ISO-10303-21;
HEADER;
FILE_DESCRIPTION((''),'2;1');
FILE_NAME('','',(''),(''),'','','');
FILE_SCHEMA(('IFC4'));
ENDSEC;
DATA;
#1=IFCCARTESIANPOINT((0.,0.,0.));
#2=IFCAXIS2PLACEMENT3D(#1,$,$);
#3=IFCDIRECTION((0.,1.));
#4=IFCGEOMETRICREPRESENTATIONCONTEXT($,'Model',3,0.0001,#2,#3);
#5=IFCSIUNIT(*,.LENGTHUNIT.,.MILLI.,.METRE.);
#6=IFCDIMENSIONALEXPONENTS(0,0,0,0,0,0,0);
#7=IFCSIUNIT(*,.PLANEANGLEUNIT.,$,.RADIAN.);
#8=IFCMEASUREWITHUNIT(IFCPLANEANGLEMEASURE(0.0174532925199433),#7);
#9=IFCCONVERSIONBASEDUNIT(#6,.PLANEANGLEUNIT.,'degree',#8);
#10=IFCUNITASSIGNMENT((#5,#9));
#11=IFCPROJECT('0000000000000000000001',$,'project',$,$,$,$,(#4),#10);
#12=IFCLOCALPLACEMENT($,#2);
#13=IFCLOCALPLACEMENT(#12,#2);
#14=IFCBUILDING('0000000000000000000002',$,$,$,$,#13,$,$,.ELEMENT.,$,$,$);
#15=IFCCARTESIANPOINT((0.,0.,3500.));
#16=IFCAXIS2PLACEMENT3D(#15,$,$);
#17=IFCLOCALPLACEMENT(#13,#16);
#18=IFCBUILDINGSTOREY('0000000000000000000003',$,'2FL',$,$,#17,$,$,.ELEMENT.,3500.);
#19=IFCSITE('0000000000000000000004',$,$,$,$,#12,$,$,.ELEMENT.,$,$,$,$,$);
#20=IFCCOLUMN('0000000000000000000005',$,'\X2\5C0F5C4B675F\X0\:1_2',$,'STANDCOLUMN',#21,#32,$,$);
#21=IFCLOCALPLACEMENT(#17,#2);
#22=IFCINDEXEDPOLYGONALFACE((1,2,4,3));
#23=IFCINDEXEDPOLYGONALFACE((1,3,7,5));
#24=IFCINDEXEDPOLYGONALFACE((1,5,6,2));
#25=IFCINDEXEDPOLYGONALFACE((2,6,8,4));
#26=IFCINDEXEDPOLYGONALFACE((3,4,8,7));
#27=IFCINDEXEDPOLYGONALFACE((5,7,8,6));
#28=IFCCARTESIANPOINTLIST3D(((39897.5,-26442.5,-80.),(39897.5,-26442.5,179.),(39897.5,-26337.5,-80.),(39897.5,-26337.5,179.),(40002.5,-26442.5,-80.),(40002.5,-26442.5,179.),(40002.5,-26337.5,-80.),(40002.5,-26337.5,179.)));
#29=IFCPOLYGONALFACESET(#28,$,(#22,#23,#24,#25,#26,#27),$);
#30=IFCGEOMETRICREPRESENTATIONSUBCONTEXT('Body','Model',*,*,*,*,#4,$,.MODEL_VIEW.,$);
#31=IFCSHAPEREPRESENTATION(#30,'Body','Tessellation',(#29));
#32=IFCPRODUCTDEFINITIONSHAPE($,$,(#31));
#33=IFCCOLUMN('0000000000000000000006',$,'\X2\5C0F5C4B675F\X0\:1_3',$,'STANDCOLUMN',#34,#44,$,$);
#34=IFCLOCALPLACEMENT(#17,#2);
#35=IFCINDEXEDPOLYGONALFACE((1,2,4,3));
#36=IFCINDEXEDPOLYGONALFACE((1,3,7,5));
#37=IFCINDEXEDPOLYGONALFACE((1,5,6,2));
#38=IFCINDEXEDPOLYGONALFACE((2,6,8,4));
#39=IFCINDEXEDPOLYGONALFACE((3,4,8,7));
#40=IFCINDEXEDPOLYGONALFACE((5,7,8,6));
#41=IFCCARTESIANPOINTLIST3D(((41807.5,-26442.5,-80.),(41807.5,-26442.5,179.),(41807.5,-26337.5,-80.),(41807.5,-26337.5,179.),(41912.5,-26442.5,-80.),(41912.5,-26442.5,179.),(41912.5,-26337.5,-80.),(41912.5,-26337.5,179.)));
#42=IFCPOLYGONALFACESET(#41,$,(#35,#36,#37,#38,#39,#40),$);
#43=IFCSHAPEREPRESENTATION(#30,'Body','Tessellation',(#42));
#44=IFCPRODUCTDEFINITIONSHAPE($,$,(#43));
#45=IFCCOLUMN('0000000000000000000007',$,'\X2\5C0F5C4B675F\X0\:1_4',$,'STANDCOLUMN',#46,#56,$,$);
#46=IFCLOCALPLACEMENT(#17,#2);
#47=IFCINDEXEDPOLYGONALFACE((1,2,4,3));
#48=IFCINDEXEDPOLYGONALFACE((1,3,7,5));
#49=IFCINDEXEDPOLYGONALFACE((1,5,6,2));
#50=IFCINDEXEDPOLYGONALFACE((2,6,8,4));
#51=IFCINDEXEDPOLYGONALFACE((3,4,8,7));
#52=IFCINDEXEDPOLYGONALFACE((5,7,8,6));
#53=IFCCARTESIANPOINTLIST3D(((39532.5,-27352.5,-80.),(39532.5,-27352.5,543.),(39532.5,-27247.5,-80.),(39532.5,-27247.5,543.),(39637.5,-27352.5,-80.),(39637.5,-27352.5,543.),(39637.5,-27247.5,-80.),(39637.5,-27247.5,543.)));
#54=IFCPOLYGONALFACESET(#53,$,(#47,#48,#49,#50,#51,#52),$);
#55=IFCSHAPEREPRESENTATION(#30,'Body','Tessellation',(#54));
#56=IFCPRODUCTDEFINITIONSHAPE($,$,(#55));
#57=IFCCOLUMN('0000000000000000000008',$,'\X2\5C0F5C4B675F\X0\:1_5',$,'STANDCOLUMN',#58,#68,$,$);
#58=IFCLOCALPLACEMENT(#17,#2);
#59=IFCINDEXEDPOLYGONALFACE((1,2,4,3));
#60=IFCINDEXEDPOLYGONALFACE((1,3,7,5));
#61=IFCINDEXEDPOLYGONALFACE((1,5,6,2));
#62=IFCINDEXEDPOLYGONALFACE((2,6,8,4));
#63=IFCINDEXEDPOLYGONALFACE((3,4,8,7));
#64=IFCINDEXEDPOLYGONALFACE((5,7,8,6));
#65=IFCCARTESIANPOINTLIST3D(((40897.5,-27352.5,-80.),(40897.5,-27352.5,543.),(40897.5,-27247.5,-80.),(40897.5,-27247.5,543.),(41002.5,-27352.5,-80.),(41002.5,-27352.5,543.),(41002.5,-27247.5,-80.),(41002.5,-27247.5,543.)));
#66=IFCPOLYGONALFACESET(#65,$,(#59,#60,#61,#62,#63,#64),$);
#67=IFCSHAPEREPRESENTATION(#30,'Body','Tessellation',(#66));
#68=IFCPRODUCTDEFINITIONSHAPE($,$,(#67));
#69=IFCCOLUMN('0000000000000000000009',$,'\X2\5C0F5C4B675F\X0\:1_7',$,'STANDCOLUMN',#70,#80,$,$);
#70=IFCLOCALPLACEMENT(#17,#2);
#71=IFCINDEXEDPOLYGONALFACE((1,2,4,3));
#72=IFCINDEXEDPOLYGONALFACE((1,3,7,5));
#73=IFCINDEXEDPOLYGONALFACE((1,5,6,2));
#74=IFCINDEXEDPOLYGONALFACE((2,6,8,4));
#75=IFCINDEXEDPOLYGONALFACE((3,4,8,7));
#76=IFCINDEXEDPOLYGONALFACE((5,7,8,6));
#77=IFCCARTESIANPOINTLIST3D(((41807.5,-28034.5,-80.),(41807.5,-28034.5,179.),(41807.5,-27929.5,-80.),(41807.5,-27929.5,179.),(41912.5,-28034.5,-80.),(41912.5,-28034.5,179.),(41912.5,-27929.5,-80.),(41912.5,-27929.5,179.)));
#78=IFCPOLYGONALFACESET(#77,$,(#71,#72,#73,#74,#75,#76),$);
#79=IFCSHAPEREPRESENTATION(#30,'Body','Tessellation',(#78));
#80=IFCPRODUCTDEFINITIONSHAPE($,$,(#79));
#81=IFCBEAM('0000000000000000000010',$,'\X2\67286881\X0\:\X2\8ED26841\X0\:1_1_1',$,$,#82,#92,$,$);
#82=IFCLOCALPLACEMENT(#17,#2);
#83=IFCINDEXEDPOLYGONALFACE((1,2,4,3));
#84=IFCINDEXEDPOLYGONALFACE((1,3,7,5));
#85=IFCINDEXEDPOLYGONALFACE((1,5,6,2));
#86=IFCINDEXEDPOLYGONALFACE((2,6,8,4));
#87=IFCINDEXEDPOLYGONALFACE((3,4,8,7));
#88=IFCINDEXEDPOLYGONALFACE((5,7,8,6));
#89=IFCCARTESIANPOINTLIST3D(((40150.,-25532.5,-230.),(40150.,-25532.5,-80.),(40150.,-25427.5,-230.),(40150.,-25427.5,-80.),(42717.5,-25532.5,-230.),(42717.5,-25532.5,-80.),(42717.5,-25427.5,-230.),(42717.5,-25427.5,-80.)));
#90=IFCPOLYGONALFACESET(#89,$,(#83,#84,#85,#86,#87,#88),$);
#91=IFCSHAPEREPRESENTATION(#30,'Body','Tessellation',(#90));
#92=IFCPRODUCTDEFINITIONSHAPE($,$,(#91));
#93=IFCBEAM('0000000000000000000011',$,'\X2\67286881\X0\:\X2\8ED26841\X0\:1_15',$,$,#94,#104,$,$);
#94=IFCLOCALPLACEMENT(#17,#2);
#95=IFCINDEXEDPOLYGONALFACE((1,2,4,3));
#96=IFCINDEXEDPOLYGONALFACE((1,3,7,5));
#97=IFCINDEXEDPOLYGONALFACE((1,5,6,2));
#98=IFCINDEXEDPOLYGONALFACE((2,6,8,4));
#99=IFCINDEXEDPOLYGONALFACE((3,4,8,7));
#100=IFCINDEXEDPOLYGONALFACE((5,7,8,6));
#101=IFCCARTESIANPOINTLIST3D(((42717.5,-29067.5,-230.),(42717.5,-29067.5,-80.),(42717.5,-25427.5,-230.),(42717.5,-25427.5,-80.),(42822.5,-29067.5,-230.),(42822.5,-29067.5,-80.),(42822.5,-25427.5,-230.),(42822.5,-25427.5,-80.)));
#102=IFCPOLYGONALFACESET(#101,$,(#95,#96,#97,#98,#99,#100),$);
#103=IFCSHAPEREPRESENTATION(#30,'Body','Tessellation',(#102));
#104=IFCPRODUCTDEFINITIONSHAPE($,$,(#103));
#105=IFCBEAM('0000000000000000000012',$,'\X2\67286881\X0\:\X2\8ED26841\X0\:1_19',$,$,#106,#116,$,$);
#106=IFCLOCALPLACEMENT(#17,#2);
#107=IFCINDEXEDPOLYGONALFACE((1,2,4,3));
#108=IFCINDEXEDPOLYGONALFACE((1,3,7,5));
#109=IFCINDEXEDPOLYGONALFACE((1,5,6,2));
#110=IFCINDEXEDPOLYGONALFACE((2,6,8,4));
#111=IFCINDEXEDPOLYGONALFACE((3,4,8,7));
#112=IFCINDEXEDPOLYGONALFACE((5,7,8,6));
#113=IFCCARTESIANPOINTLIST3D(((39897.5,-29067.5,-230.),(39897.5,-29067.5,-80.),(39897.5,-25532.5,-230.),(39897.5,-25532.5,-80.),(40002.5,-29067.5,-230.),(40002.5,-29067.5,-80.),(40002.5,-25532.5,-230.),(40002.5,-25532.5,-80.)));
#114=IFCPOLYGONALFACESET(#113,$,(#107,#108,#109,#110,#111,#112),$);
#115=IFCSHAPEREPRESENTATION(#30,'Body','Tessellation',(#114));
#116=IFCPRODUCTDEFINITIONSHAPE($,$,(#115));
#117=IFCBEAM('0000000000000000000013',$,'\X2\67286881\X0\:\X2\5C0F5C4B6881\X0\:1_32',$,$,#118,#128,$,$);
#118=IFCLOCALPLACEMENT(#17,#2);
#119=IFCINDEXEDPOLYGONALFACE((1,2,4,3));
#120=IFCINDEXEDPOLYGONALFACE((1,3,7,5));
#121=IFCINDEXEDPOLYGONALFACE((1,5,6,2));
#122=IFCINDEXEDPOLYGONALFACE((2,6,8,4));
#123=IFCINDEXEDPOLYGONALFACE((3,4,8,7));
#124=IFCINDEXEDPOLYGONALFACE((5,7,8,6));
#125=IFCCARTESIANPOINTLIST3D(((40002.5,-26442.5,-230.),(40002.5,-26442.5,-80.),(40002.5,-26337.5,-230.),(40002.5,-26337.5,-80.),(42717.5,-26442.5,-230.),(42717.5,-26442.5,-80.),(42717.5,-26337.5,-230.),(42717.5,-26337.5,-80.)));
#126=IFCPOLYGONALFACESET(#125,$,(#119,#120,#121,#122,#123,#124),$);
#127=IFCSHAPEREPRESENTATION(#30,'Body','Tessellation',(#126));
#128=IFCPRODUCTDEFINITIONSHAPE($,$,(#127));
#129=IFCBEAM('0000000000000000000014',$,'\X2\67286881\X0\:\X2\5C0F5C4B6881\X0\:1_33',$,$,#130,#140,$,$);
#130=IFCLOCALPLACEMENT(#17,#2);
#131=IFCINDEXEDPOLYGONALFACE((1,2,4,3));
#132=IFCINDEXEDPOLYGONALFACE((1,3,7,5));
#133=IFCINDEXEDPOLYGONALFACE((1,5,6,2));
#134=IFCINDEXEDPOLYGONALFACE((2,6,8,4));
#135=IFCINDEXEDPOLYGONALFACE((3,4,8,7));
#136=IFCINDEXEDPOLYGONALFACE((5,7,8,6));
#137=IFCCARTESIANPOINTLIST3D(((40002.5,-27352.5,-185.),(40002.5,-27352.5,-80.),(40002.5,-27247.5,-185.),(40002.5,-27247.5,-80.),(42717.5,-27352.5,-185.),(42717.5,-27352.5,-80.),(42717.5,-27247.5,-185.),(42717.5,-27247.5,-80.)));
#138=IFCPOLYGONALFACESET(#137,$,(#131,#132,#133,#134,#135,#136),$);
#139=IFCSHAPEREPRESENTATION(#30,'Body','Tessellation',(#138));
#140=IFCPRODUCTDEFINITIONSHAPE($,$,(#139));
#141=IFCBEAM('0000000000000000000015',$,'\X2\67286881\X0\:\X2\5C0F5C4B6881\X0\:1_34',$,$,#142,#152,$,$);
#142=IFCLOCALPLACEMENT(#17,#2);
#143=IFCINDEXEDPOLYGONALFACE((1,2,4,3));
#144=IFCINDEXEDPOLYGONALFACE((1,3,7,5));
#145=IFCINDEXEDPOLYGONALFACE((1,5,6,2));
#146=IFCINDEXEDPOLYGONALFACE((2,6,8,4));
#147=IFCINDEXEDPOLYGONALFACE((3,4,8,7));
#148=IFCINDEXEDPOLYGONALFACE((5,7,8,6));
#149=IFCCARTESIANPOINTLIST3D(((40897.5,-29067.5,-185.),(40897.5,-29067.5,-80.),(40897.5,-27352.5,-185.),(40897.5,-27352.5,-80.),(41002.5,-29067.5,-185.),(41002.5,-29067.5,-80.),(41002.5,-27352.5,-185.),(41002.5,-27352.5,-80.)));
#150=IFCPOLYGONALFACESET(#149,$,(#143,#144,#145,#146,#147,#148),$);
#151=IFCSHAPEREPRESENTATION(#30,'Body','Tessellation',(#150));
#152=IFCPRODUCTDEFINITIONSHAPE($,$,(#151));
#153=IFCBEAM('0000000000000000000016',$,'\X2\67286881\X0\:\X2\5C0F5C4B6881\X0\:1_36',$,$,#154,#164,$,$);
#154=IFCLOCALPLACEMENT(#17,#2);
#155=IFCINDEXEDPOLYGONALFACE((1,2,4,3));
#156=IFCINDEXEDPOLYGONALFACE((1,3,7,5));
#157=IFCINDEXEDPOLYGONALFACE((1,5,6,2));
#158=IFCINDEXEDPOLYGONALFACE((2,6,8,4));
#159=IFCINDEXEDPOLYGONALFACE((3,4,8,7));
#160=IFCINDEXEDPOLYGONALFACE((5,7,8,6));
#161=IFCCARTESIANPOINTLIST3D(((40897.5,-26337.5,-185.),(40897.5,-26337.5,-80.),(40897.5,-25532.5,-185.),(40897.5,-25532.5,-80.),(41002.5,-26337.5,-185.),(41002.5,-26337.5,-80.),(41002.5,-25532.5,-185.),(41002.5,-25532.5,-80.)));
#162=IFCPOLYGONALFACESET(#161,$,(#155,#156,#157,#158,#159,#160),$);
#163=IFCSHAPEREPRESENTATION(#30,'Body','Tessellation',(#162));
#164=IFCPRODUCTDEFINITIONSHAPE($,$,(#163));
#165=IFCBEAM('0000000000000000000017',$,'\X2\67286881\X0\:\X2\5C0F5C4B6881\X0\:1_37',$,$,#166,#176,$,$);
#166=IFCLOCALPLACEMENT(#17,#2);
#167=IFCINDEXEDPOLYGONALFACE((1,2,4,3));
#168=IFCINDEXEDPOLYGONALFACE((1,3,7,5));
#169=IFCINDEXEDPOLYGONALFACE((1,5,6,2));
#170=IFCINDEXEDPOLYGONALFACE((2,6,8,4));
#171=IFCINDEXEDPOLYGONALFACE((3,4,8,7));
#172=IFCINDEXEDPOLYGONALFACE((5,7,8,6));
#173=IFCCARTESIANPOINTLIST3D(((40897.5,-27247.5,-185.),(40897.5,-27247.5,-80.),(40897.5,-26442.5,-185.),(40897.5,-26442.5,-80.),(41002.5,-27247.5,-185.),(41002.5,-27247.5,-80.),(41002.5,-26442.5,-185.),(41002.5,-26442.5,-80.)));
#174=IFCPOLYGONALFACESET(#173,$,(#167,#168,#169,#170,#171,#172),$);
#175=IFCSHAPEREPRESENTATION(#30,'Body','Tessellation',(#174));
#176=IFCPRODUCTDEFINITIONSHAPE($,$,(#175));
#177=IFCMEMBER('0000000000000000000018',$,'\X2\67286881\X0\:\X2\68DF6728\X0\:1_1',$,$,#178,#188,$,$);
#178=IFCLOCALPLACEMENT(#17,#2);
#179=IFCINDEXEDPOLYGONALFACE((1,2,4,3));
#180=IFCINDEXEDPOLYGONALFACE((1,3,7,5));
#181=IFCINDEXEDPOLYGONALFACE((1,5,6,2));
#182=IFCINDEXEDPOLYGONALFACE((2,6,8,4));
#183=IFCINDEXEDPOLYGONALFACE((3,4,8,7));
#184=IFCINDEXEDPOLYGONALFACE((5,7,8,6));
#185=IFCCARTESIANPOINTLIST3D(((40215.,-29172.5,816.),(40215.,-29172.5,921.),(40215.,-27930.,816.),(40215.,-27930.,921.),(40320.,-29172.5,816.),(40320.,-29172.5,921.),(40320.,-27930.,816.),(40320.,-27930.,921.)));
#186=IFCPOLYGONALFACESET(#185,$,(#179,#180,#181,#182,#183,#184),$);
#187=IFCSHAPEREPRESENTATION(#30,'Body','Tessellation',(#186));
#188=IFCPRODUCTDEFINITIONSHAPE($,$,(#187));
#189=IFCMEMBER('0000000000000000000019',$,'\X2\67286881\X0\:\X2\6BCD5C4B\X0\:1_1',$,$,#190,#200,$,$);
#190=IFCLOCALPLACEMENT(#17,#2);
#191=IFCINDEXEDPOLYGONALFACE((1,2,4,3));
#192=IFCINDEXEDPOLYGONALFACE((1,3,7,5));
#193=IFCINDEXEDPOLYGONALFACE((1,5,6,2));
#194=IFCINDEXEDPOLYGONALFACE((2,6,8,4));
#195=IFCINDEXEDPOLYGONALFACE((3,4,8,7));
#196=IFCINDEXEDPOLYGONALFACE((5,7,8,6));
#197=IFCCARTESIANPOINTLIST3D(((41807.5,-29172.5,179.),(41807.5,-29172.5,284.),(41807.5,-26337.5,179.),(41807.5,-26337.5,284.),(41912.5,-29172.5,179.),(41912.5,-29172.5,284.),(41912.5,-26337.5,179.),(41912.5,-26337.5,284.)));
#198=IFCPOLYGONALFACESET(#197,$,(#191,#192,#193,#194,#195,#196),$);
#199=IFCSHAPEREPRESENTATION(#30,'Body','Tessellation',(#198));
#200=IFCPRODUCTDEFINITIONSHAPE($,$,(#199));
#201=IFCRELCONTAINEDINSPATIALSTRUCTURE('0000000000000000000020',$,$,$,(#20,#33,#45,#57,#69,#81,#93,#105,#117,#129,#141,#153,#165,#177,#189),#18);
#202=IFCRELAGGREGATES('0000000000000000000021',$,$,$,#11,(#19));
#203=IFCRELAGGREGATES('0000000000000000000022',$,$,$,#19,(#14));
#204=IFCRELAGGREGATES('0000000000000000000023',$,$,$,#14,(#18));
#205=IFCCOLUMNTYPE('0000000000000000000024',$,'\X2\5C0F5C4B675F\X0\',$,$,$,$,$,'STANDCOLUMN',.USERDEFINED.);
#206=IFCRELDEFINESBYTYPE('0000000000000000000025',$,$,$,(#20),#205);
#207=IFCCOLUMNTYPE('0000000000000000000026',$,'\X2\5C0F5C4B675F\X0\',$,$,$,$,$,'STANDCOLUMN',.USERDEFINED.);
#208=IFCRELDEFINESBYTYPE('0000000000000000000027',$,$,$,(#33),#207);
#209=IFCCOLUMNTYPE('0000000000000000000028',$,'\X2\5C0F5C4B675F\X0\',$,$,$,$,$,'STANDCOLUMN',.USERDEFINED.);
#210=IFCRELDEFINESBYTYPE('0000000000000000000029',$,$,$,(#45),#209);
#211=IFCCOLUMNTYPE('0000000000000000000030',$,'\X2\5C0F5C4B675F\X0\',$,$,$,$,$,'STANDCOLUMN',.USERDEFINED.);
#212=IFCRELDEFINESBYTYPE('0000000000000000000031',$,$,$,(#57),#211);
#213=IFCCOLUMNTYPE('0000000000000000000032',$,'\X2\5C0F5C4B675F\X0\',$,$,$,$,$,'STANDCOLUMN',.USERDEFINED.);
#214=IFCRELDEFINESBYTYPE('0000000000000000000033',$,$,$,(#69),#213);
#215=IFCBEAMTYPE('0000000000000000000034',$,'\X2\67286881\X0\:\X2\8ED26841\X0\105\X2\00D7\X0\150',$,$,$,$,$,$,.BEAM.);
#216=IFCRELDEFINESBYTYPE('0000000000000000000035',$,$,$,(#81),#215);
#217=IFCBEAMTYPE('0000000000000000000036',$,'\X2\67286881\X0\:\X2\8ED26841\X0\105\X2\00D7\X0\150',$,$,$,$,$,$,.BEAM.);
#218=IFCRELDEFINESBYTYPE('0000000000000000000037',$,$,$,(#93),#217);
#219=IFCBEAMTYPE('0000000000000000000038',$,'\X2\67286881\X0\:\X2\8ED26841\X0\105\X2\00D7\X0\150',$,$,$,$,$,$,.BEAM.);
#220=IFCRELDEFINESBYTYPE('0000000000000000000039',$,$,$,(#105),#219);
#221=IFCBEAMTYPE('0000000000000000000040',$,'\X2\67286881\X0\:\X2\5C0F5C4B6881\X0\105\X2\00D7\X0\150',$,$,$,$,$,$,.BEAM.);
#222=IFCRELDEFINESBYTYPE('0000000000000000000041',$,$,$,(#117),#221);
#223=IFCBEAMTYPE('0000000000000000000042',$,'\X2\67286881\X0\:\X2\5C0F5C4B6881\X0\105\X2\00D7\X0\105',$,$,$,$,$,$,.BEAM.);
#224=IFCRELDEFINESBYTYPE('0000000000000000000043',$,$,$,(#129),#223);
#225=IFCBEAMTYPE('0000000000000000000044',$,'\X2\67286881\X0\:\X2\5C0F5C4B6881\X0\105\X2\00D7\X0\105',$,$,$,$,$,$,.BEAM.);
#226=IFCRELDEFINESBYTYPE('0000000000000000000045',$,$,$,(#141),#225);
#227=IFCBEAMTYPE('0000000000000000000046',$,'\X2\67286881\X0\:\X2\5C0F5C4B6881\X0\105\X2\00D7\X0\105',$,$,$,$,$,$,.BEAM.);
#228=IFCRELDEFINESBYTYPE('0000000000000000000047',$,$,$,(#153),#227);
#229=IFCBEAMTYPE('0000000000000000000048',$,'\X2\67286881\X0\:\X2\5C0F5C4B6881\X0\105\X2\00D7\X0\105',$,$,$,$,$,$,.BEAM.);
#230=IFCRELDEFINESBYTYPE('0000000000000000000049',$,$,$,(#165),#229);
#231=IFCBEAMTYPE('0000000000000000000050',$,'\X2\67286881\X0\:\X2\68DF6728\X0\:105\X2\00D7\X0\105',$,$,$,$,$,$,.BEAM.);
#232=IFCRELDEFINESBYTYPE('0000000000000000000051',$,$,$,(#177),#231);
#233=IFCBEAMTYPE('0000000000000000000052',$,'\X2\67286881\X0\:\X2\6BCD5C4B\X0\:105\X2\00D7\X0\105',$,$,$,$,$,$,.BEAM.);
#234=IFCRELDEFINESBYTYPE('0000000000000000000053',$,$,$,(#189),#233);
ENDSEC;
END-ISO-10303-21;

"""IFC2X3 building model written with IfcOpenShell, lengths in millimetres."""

from ifc_helpers import new_model, entity, si_unit, converted_unit, direction, frame, origin, origin_with_axes, origin_2d, place, context, subcontext, project, spatial, rectangle, extrude, type_object, element, save


model = new_model("IFC2X3")

# Units and contexts
model_context = context("Model", 3, precision=0.0001, world=origin(), true_north=direction((0.0, 1.0)))
body_context = subcontext(model_context, "Body", "Model", "MODEL_VIEW")
ifc_project = project(units=[si_unit("LENGTHUNIT", "METRE", prefix="MILLI"), converted_unit("PLANEANGLEUNIT", "degree", entity("IfcPlaneAngleMeasure", 0.0174532925199433), si_unit("PLANEANGLEUNIT", "RADIAN"), dimensions=[0, 0, 0, 0, 0, 0, 0])], contexts=[model_context])

# Site, building, storey
site_placement = place(None, origin())
site = spatial("IfcSite", under=ifc_project, at=site_placement, CompositionType="ELEMENT")
building_placement = place(site_placement, origin())
building = spatial("IfcBuilding", under=site, at=building_placement, CompositionType="ELEMENT")
storey_placement = place(building_placement, frame((0.0, 0.0, 3500.0)))
storey = spatial("IfcBuildingStorey", under=building, at=storey_placement, Name="2FL", CompositionType="ELEMENT", Elevation=3500.0)

# Columns
column_type_1 = type_object("IfcColumnType", Name="小屋束", ElementType="STANDCOLUMN", PredefinedType="USERDEFINED")
column_1_placement = place(storey_placement, frame((39950.0, -26390.0, -80.0)))
element("IfcColumn", 1, at=column_1_placement, inside=storey, type_object=column_type_1, Name="小屋束:1_2", ObjectType="STANDCOLUMN", context=body_context, shape_type="SweptSolid", body=[
    extrude(rectangle(XDim=105.0, YDim=105.0, at=origin_2d()), origin_with_axes(), (0.0, 0.0, 1.0), 259.0),
])
column_type_2 = type_object("IfcColumnType", Name="小屋束", ElementType="STANDCOLUMN", PredefinedType="USERDEFINED")
column_2_placement = place(storey_placement, frame((41860.0, -26390.0, -80.0)))
element("IfcColumn", 2, at=column_2_placement, inside=storey, type_object=column_type_2, Name="小屋束:1_3", ObjectType="STANDCOLUMN", context=body_context, shape_type="SweptSolid", body=[
    extrude(rectangle(XDim=105.0, YDim=105.0, at=origin_2d()), origin_with_axes(), (0.0, 0.0, 1.0), 259.0),
])
column_type_3 = type_object("IfcColumnType", Name="小屋束", ElementType="STANDCOLUMN", PredefinedType="USERDEFINED")
column_3_placement = place(storey_placement, frame((39585.0, -27300.0, -80.0)))
element("IfcColumn", 3, at=column_3_placement, inside=storey, type_object=column_type_3, Name="小屋束:1_4", ObjectType="STANDCOLUMN", context=body_context, shape_type="SweptSolid", body=[
    extrude(rectangle(XDim=105.0, YDim=105.0, at=origin_2d()), origin_with_axes(), (0.0, 0.0, 1.0), 623.0),
])
column_type_4 = type_object("IfcColumnType", Name="小屋束", ElementType="STANDCOLUMN", PredefinedType="USERDEFINED")
column_4_placement = place(storey_placement, frame((40950.0, -27300.0, -80.0)))
element("IfcColumn", 4, at=column_4_placement, inside=storey, type_object=column_type_4, Name="小屋束:1_5", ObjectType="STANDCOLUMN", context=body_context, shape_type="SweptSolid", body=[
    extrude(rectangle(XDim=105.0, YDim=105.0, at=origin_2d()), origin_with_axes(), (0.0, 0.0, 1.0), 623.0),
])
column_type_5 = type_object("IfcColumnType", Name="小屋束", ElementType="STANDCOLUMN", PredefinedType="USERDEFINED")
column_5_placement = place(storey_placement, frame((41860.0, -27982.0, -80.0)))
element("IfcColumn", 5, at=column_5_placement, inside=storey, type_object=column_type_5, Name="小屋束:1_7", ObjectType="STANDCOLUMN", context=body_context, shape_type="SweptSolid", body=[
    extrude(rectangle(XDim=105.0, YDim=105.0, at=origin_2d()), origin_with_axes(), (0.0, 0.0, 1.0), 259.0),
])

# Beams
beam_type_1 = type_object("IfcBeamType", Name="木梁:軒桁105×150", PredefinedType="BEAM")
beam_1_placement = place(storey_placement, frame((40150.0, -25480.0, -155.0), z_axis=(1.0, 0.0, 0.0), x_axis=(0.0, 1.0, 0.0)))
element("IfcBeam", 6, at=beam_1_placement, inside=storey, type_object=beam_type_1, Name="木梁:軒桁:1_1_1", context=body_context, shape_type="SweptSolid", body=[
    extrude(rectangle(XDim=105.0, YDim=150.0, at=origin_2d()), origin_with_axes(), (0.0, 0.0, 1.0), 2567.5),
])
beam_type_2 = type_object("IfcBeamType", Name="木梁:軒桁105×150", PredefinedType="BEAM")
beam_2_placement = place(storey_placement, frame((42770.0, -25427.5, -155.0), z_axis=(0.0, -1.0, 0.0), x_axis=(1.0, 0.0, 0.0)))
element("IfcBeam", 7, at=beam_2_placement, inside=storey, type_object=beam_type_2, Name="木梁:軒桁:1_15", context=body_context, shape_type="SweptSolid", body=[
    extrude(rectangle(XDim=105.0, YDim=150.0, at=origin_2d()), origin_with_axes(), (0.0, 0.0, 1.0), 3640.0),
])
beam_type_3 = type_object("IfcBeamType", Name="木梁:軒桁105×150", PredefinedType="BEAM")
beam_3_placement = place(storey_placement, frame((39950.0, -25532.5, -155.0), z_axis=(0.0, -1.0, 0.0), x_axis=(1.0, 0.0, 0.0)))
element("IfcBeam", 8, at=beam_3_placement, inside=storey, type_object=beam_type_3, Name="木梁:軒桁:1_19", context=body_context, shape_type="SweptSolid", body=[
    extrude(rectangle(XDim=105.0, YDim=150.0, at=origin_2d()), origin_with_axes(), (0.0, 0.0, 1.0), 3535.0),
])
beam_type_4 = type_object("IfcBeamType", Name="木梁:小屋梁105×150", PredefinedType="BEAM")
beam_4_placement = place(storey_placement, frame((40002.5, -26390.0, -155.0), z_axis=(1.0, 0.0, 0.0), x_axis=(0.0, 1.0, 0.0)))
element("IfcBeam", 9, at=beam_4_placement, inside=storey, type_object=beam_type_4, Name="木梁:小屋梁:1_32", context=body_context, shape_type="SweptSolid", body=[
    extrude(rectangle(XDim=105.0, YDim=150.0, at=origin_2d()), origin_with_axes(), (0.0, 0.0, 1.0), 2715.0),
])
beam_type_5 = type_object("IfcBeamType", Name="木梁:小屋梁105×105", PredefinedType="BEAM")
beam_5_placement = place(storey_placement, frame((40002.5, -27300.0, -132.5), z_axis=(1.0, 0.0, 0.0), x_axis=(0.0, 1.0, 0.0)))
element("IfcBeam", 10, at=beam_5_placement, inside=storey, type_object=beam_type_5, Name="木梁:小屋梁:1_33", context=body_context, shape_type="SweptSolid", body=[
    extrude(rectangle(XDim=105.0, YDim=105.0, at=origin_2d()), origin_with_axes(), (0.0, 0.0, 1.0), 2715.0),
])
beam_type_6 = type_object("IfcBeamType", Name="木梁:小屋梁105×105", PredefinedType="BEAM")
beam_6_placement = place(storey_placement, frame((40950.0, -27352.5, -132.5), z_axis=(0.0, -1.0, 0.0), x_axis=(1.0, 0.0, 0.0)))
element("IfcBeam", 11, at=beam_6_placement, inside=storey, type_object=beam_type_6, Name="木梁:小屋梁:1_34", context=body_context, shape_type="SweptSolid", body=[
    extrude(rectangle(XDim=105.0, YDim=105.0, at=origin_2d()), origin_with_axes(), (0.0, 0.0, 1.0), 1715.0),
])
beam_type_7 = type_object("IfcBeamType", Name="木梁:小屋梁105×105", PredefinedType="BEAM")
beam_7_placement = place(storey_placement, frame((40950.0, -25532.5, -132.5), z_axis=(0.0, -1.0, 0.0), x_axis=(1.0, 0.0, 0.0)))
element("IfcBeam", 12, at=beam_7_placement, inside=storey, type_object=beam_type_7, Name="木梁:小屋梁:1_36", context=body_context, shape_type="SweptSolid", body=[
    extrude(rectangle(XDim=105.0, YDim=105.0, at=origin_2d()), origin_with_axes(), (0.0, 0.0, 1.0), 805.0),
])
beam_type_8 = type_object("IfcBeamType", Name="木梁:小屋梁105×105", PredefinedType="BEAM")
beam_8_placement = place(storey_placement, frame((40950.0, -26442.5, -132.5), z_axis=(0.0, -1.0, 0.0), x_axis=(1.0, 0.0, 0.0)))
element("IfcBeam", 13, at=beam_8_placement, inside=storey, type_object=beam_type_8, Name="木梁:小屋梁:1_37", context=body_context, shape_type="SweptSolid", body=[
    extrude(rectangle(XDim=105.0, YDim=105.0, at=origin_2d()), origin_with_axes(), (0.0, 0.0, 1.0), 805.0),
])

# Members
beam_type_9 = type_object("IfcBeamType", Name="木梁:棟木:105×105", PredefinedType="BEAM")
member_1_placement = place(storey_placement, frame((40267.5, -27930.0, 868.5), z_axis=(0.0, -1.0, 0.0), x_axis=(-1.0, 0.0, 0.0)))
element("IfcMember", 14, at=member_1_placement, inside=storey, type_object=beam_type_9, Name="木梁:棟木:1_1", context=body_context, shape_type="SweptSolid", body=[
    extrude(rectangle(XDim=105.0, YDim=105.0, at=origin_2d()), origin_with_axes(), (0.0, 0.0, 1.0), 1242.5),
])
beam_type_10 = type_object("IfcBeamType", Name="木梁:母屋:105×105", PredefinedType="BEAM")
member_2_placement = place(storey_placement, frame((41860.0, -26337.5, 231.5), z_axis=(0.0, -1.0, 0.0), x_axis=(-1.0, 0.0, 0.0)))
element("IfcMember", 15, at=member_2_placement, inside=storey, type_object=beam_type_10, Name="木梁:母屋:1_1", context=body_context, shape_type="SweptSolid", body=[
    extrude(rectangle(XDim=105.0, YDim=105.0, at=origin_2d()), origin_with_axes(), (0.0, 0.0, 1.0), 2835.0),
])

save(model, "model.ifc")
